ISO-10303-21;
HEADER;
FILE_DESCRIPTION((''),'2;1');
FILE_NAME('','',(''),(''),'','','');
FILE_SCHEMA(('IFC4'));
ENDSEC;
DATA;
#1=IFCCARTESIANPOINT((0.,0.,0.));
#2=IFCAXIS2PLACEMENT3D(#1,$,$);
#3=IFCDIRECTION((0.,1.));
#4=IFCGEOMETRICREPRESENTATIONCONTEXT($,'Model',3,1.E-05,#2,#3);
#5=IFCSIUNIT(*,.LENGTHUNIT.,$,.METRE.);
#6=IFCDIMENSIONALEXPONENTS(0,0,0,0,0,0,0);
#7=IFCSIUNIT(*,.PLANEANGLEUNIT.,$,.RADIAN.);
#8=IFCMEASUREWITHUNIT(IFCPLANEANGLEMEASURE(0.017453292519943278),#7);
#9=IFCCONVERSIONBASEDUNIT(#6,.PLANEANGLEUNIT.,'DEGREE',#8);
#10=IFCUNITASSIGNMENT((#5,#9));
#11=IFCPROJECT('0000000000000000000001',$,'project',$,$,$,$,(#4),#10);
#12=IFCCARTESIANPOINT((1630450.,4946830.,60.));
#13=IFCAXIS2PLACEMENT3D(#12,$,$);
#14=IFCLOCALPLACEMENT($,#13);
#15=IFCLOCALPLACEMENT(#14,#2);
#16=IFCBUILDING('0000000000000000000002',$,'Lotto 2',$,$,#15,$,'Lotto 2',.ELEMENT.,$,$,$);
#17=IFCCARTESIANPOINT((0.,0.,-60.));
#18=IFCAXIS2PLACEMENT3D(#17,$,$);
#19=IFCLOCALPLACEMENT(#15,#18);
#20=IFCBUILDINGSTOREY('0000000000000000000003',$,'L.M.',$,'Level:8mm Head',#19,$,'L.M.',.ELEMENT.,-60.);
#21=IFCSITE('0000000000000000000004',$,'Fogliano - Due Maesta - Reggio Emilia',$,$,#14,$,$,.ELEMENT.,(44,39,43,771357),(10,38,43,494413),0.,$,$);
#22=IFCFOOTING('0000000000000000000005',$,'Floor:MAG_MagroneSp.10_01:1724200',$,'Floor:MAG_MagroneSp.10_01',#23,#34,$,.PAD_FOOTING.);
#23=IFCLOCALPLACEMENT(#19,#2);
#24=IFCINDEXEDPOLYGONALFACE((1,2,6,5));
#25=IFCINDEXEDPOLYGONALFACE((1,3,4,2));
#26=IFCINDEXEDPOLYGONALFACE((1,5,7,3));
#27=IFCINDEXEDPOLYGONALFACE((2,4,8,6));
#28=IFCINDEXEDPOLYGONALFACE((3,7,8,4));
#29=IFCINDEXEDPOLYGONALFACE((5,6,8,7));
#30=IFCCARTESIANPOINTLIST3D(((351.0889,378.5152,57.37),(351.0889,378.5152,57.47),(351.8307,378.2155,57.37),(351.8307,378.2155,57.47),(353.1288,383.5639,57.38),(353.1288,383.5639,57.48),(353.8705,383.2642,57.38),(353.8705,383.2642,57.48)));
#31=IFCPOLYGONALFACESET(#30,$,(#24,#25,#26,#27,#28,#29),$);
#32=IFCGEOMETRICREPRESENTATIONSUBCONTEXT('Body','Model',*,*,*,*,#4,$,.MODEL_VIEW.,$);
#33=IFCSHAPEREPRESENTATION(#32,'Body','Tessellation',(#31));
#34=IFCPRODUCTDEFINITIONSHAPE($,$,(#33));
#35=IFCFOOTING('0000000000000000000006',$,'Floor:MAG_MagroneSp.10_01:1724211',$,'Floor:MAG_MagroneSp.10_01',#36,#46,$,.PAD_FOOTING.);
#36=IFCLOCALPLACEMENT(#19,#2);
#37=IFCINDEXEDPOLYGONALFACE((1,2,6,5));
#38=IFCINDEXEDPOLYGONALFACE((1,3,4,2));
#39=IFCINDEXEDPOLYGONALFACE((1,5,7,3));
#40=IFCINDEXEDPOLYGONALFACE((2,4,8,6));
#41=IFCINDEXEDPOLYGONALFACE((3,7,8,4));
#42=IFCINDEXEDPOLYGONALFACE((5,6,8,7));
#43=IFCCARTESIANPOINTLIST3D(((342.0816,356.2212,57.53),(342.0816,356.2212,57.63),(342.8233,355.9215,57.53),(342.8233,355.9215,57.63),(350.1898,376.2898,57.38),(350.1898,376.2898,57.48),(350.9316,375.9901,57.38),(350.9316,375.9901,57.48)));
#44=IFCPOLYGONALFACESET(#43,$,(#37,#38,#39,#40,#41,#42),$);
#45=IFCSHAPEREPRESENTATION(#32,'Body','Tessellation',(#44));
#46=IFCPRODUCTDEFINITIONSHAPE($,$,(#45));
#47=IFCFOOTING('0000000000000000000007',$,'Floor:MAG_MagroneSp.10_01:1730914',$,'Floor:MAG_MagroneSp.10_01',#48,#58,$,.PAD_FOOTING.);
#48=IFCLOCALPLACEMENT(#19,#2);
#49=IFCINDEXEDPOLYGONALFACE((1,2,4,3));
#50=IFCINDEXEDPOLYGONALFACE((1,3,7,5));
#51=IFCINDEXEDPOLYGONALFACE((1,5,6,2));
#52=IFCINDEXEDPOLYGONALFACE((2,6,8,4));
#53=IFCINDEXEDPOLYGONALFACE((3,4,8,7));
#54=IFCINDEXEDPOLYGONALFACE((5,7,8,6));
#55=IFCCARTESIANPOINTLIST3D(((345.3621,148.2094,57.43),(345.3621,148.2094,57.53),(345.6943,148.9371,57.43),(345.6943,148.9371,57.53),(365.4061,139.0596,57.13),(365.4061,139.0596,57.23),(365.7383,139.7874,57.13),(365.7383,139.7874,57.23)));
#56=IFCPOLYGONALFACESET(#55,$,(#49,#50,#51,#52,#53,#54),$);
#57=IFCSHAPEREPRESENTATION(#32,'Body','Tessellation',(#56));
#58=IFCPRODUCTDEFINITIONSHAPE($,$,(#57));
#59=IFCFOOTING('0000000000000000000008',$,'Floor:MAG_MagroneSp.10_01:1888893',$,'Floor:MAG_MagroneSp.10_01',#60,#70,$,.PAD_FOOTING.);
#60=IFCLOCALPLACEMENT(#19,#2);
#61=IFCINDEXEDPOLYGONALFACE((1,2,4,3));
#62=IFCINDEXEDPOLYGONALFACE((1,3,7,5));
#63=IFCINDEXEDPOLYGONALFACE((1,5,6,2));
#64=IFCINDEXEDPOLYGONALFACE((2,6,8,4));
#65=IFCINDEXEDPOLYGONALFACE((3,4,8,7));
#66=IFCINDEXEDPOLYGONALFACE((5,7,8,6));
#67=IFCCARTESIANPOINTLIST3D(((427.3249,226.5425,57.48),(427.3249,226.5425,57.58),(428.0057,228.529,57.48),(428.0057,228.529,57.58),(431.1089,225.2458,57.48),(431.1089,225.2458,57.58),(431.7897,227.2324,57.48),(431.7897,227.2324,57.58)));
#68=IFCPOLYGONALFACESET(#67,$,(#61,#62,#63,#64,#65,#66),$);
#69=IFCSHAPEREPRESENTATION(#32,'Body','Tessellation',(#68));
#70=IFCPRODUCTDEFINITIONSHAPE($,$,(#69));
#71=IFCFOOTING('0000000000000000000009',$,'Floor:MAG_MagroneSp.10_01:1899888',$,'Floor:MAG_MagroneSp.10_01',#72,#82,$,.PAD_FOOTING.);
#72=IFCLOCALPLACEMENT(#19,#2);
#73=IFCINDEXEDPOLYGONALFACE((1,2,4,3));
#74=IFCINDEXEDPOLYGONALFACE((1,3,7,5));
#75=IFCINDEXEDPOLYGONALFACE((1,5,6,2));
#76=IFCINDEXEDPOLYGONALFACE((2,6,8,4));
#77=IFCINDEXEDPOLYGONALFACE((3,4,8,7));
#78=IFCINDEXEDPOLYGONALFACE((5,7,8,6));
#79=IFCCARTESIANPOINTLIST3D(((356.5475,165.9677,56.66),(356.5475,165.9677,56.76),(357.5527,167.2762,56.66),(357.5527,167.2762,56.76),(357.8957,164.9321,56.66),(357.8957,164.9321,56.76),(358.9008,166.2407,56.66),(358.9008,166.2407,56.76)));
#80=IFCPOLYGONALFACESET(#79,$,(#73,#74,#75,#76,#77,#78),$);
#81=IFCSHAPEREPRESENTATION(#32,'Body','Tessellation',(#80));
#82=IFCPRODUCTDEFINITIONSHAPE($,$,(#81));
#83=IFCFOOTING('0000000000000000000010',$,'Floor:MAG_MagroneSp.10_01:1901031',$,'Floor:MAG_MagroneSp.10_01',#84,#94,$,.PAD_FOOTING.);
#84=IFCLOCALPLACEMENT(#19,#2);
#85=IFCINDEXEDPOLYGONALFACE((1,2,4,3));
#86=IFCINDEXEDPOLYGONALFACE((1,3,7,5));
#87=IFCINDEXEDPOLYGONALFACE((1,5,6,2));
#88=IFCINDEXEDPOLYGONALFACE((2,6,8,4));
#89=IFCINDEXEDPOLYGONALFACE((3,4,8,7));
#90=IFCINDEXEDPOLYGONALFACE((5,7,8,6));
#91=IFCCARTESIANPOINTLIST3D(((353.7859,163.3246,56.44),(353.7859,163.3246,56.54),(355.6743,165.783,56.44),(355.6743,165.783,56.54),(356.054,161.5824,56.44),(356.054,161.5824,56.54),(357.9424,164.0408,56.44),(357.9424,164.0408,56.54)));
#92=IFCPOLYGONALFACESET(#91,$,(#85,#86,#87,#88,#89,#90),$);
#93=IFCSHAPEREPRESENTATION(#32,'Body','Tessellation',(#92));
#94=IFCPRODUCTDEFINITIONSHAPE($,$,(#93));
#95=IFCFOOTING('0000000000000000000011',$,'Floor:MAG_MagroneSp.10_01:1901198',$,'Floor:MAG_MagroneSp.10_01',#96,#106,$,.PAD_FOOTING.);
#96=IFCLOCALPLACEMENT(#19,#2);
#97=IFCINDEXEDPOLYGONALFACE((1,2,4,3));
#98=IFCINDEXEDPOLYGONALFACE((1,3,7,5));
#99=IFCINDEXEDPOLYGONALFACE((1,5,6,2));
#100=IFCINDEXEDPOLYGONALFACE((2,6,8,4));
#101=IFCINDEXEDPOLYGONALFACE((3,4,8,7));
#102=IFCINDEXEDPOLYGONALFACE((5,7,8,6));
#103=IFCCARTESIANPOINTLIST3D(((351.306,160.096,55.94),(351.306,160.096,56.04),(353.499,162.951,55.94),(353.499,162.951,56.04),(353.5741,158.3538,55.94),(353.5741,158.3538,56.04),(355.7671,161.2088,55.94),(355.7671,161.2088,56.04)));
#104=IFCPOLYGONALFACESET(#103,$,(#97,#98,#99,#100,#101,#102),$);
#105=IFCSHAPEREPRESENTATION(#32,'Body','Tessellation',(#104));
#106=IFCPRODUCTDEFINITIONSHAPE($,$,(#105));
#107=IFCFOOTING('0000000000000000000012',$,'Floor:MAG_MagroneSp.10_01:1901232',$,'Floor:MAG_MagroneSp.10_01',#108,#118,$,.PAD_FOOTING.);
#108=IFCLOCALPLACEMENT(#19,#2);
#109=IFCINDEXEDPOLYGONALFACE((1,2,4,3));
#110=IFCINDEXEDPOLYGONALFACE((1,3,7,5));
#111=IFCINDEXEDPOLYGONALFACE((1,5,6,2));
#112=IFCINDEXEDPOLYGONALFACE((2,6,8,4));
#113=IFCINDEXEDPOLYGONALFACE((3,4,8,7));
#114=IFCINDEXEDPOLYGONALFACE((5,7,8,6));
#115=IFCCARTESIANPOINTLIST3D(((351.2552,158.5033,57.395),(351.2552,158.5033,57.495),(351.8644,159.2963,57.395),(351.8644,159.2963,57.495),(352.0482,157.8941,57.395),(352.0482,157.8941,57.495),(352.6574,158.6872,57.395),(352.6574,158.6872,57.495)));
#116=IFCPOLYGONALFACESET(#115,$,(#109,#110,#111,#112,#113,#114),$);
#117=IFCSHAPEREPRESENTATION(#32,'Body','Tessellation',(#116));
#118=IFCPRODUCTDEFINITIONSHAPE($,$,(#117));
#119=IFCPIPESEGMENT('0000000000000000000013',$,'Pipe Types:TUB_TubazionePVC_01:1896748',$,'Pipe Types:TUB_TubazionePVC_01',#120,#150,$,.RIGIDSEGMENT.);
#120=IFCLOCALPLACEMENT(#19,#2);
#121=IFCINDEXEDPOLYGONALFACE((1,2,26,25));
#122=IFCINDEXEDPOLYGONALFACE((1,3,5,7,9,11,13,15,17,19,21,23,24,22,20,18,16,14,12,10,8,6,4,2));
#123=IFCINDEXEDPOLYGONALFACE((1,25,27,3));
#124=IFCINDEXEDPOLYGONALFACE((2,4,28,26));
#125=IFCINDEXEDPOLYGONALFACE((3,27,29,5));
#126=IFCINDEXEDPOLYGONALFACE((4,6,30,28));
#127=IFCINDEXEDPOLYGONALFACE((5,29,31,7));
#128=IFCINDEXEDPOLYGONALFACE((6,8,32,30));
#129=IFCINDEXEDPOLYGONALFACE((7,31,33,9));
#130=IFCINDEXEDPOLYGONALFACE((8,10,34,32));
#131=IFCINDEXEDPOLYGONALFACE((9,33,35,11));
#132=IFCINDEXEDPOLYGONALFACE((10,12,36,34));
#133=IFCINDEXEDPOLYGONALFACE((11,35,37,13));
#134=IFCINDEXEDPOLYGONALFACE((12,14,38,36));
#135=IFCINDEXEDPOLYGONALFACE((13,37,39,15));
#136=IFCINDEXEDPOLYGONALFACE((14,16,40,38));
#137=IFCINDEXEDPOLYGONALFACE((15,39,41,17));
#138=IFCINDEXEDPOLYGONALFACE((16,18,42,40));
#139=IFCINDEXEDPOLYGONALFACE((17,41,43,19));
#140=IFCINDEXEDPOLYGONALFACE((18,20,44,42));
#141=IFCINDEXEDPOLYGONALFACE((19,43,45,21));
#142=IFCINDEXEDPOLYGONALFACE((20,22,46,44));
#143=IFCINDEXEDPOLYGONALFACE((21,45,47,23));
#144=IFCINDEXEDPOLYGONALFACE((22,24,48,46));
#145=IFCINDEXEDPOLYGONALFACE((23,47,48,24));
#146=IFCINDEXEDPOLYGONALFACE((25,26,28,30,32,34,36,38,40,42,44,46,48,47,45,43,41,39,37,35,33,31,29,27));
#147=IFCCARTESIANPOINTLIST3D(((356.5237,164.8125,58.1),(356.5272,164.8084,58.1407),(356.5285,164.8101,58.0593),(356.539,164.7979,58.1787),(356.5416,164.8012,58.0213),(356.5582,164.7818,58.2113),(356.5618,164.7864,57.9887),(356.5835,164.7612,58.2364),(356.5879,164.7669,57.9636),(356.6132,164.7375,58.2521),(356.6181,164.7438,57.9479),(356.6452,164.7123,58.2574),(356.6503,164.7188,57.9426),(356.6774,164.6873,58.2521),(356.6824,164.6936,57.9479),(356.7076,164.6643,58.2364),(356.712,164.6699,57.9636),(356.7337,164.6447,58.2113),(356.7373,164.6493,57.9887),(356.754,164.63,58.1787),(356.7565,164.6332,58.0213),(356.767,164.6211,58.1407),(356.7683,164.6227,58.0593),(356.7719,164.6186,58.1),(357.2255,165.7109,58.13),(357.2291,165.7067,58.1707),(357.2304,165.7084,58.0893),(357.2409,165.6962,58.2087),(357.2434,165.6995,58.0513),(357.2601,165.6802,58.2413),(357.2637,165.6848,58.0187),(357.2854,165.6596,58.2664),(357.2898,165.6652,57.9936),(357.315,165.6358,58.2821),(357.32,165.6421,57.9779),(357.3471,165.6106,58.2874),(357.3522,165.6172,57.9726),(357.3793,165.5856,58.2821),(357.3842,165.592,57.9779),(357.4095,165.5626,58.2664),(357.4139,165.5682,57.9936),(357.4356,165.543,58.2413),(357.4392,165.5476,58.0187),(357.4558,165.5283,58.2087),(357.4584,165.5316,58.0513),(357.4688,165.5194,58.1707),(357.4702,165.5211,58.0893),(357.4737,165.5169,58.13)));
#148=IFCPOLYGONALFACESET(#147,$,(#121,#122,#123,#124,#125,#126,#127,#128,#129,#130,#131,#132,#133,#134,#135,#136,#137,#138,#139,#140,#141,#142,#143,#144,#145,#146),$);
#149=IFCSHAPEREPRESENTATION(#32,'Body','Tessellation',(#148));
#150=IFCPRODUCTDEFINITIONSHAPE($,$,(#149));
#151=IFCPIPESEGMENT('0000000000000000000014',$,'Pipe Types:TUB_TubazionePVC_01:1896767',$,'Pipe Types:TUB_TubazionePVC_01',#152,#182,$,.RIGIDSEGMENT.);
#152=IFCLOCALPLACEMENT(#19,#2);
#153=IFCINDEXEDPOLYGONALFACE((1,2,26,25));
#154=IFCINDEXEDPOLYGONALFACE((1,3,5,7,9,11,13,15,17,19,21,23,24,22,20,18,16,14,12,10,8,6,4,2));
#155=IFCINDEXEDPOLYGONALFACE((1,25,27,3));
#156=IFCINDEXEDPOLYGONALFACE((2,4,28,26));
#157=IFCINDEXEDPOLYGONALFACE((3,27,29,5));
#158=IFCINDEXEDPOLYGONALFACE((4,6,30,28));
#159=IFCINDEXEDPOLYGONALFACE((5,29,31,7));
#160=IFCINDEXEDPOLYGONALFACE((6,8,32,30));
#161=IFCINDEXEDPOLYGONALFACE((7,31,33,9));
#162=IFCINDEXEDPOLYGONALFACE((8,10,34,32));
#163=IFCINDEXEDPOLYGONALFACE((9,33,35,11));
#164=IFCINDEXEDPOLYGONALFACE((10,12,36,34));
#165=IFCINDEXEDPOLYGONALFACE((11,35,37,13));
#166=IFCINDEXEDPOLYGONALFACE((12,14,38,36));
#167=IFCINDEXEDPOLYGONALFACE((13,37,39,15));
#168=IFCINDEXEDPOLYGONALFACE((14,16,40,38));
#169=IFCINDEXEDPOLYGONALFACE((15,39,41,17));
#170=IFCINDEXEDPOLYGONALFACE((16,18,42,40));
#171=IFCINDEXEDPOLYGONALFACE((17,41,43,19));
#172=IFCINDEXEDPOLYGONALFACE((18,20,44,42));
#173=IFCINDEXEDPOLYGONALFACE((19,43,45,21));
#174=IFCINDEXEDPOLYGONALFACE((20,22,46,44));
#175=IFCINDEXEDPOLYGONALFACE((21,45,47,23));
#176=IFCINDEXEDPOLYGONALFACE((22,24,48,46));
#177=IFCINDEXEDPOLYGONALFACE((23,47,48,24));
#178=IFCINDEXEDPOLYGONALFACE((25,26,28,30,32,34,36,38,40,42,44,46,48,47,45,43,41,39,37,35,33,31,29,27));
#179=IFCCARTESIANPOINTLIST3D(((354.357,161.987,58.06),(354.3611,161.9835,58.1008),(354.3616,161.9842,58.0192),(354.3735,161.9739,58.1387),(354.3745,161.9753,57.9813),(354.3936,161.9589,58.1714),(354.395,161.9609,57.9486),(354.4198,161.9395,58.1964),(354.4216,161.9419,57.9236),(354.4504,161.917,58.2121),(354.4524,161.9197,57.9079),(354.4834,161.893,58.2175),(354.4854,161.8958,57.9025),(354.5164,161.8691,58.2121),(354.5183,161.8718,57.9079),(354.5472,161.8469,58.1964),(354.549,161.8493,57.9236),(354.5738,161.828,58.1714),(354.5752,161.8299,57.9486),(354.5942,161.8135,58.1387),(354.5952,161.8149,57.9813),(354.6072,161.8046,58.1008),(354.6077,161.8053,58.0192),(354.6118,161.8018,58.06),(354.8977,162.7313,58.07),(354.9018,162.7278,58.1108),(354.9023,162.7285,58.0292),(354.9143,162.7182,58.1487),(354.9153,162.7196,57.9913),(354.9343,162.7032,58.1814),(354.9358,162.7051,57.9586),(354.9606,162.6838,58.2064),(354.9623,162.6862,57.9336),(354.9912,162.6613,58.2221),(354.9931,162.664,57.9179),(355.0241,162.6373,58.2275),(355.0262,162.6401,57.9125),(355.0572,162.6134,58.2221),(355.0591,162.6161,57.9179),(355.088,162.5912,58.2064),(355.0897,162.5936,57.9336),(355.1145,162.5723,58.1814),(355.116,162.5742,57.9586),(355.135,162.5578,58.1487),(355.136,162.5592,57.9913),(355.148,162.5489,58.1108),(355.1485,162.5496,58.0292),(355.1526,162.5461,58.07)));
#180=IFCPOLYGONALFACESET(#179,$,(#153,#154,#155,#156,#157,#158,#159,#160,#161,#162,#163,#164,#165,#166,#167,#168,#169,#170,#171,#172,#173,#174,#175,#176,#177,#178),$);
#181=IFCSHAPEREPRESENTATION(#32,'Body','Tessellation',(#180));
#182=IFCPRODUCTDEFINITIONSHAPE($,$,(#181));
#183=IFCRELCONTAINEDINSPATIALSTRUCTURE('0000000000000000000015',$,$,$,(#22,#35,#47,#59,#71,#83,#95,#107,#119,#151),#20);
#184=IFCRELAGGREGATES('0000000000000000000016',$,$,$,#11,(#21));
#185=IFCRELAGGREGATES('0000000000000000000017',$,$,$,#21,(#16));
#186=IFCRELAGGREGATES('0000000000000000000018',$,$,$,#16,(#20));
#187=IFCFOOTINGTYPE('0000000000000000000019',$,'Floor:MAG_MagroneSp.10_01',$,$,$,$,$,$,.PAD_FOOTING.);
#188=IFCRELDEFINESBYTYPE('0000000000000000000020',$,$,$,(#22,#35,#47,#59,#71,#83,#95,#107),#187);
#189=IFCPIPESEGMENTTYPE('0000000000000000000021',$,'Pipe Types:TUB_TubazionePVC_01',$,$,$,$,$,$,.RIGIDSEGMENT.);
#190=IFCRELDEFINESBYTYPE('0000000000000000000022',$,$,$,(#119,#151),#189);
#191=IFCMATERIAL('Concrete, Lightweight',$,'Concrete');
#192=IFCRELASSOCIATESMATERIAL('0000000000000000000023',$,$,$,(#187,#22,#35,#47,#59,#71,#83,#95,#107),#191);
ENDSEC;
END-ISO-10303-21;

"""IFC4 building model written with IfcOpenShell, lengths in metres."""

from ifc_helpers import new_model, entity, si_unit, converted_unit, direction, frame, frame_2d, origin, place, context, subcontext, project, spatial, arc, indexed_curve, rectangle, outline, extrude, material, type_object, element, save


model = new_model("IFC4")

# Units and contexts
model_context = context("Model", 3, precision=1e-05, world=origin(), true_north=direction((0.0, 1.0)))
body_context = subcontext(model_context, "Body", "Model", "MODEL_VIEW")
ifc_project = project(units=[si_unit("LENGTHUNIT", "METRE"), converted_unit("PLANEANGLEUNIT", "DEGREE", entity("IfcPlaneAngleMeasure", 0.017453292519943278), si_unit("PLANEANGLEUNIT", "RADIAN"), dimensions=[0, 0, 0, 0, 0, 0, 0])], contexts=[model_context])

# Site, building, storey
site_placement = place(None, frame((1630450.0, 4946830.0, 60.0)))
site = spatial("IfcSite", under=ifc_project, at=site_placement, Name="Fogliano - Due Maesta - Reggio Emilia", CompositionType="ELEMENT", RefLatitude=(44, 39, 43, 771357), RefLongitude=(10, 38, 43, 494413), RefElevation=0.0)
building_placement = place(site_placement, origin())
building = spatial("IfcBuilding", under=site, at=building_placement, Name="Lotto 2", LongName="Lotto 2", CompositionType="ELEMENT")
storey_placement = place(building_placement, frame((0.0, 0.0, -60.0)))
storey = spatial("IfcBuildingStorey", under=building, at=storey_placement, Name="L.M.", ObjectType="Level:8mm Head", LongName="L.M.", CompositionType="ELEMENT", Elevation=-60.0)

# Footings
ifc_material_1 = material(Name="Concrete, Lightweight", Category="Concrete")
footing_type = type_object("IfcFootingType", Name="Floor:MAG_MagroneSp.10_01", PredefinedType="PAD_FOOTING", material=ifc_material_1)
footing_1_placement = place(storey_placement, frame((351.0889, 378.2155, 57.37)))
element("IfcFooting", 1, at=footing_1_placement, inside=storey, type_object=footing_type, material=ifc_material_1, Name="Floor:MAG_MagroneSp.10_01:1724200", ObjectType="Floor:MAG_MagroneSp.10_01", PredefinedType="PAD_FOOTING", context=body_context, shape_type="SweptSolid", body=[
    extrude(rectangle(XDim=0.8, YDim=5.4452, at=frame_2d((0.0, 0.0), x_axis=(0.927184, -0.374606))), frame((1.3908, 2.6742, 0.105), z_axis=(-0.000688, -0.001703, 0.999998), x_axis=(1.0, -0.000001, 0.000688)), (-0.000688, -0.001703, -0.999998), 0.1),
])
footing_2_placement = place(storey_placement, frame((342.0816, 355.9215, 57.38)))
element("IfcFooting", 2, at=footing_2_placement, inside=storey, type_object=footing_type, material=ifc_material_1, Name="Floor:MAG_MagroneSp.10_01:1724211", ObjectType="Floor:MAG_MagroneSp.10_01", PredefinedType="PAD_FOOTING", context=body_context, shape_type="SweptSolid", body=[
    extrude(rectangle(XDim=0.8, YDim=21.6452, at=frame_2d((0.0, 0.0), x_axis=(0.927187, -0.374599))), frame((4.425, 10.1841, 0.175), z_axis=(0.002596, 0.006425, 0.999976), x_axis=(0.999997, -0.000017, -0.002596)), (0.002596, 0.006425, -0.999976), 0.1),
])
footing_3_placement = place(storey_placement, frame((345.3621, 139.0596, 57.13)))
element("IfcFooting", 3, at=footing_3_placement, inside=storey, type_object=footing_type, material=ifc_material_1, Name="Floor:MAG_MagroneSp.10_01:1730914", ObjectType="Floor:MAG_MagroneSp.10_01", PredefinedType="PAD_FOOTING", context=body_context, shape_type="SweptSolid", body=[
    extrude(rectangle(XDim=0.8, YDim=22.0356, at=frame_2d((0.0, 0.0), x_axis=(0.415297, 0.909686))), frame((10.1881, 4.9388, 0.25), z_axis=(0.012386, -0.005654, 0.999907), x_axis=(0.999923, 0.00007, -0.012386)), (0.012386, -0.005654, -0.999907), 0.1),
])
footing_4_placement = place(storey_placement, origin())
element("IfcFooting", 4, at=footing_4_placement, inside=storey, type_object=footing_type, material=ifc_material_1, Name="Floor:MAG_MagroneSp.10_01:1888893", ObjectType="Floor:MAG_MagroneSp.10_01", PredefinedType="PAD_FOOTING", context=body_context, shape_type="SweptSolid", body=[
    extrude(outline(indexed_curve([(-2.0, -1.05), (2.0, -1.05), (2.0, 1.05), (-2.0, 1.05), (-2.0, -1.05)], self_intersect=False)), frame((429.5573, 226.8874, 57.58), z_axis=(0.0, 0.0, -1.0), x_axis=(0.945998, -0.324172, 0.0)), (0.0, 0.0, 1.0), 0.1),
])
footing_5_placement = place(storey_placement, origin())
element("IfcFooting", 5, at=footing_5_placement, inside=storey, type_object=footing_type, material=ifc_material_1, Name="Floor:MAG_MagroneSp.10_01:1899888", ObjectType="Floor:MAG_MagroneSp.10_01", PredefinedType="PAD_FOOTING", context=body_context, shape_type="SweptSolid", body=[
    extrude(outline(indexed_curve([(-0.85, -0.825), (0.85, -0.825), (0.85, 0.825), (-0.85, 0.825), (-0.85, -0.825)], self_intersect=False)), frame((357.7242, 166.1042, 56.76), z_axis=(0.0, 0.0, -1.0), x_axis=(0.793045, -0.609163, 0.0)), (0.0, 0.0, 1.0), 0.1),
])
footing_6_placement = place(storey_placement, origin())
element("IfcFooting", 6, at=footing_6_placement, inside=storey, type_object=footing_type, material=ifc_material_1, Name="Floor:MAG_MagroneSp.10_01:1901031", ObjectType="Floor:MAG_MagroneSp.10_01", PredefinedType="PAD_FOOTING", context=body_context, shape_type="SweptSolid", body=[
    extrude(outline(indexed_curve([(-1.43, -1.55), (1.43, -1.55), (1.43, 1.55), (-1.43, 1.55), (-1.43, -1.55)], self_intersect=False)), frame((355.8642, 163.6827, 56.54), z_axis=(0.0, 0.0, -1.0), x_axis=(0.793045, -0.609163, 0.0)), (0.0, 0.0, 1.0), 0.1),
])
footing_7_placement = place(storey_placement, origin())
element("IfcFooting", 7, at=footing_7_placement, inside=storey, type_object=footing_type, material=ifc_material_1, Name="Floor:MAG_MagroneSp.10_01:1901198", ObjectType="Floor:MAG_MagroneSp.10_01", PredefinedType="PAD_FOOTING", context=body_context, shape_type="SweptSolid", body=[
    extrude(outline(indexed_curve([(-1.43, -1.8), (1.43, -1.8), (1.43, 1.8), (-1.43, 1.8), (-1.43, -1.8)], self_intersect=False)), frame((353.5365, 160.6524, 56.04), z_axis=(0.0, 0.0, -1.0), x_axis=(0.793045, -0.609163, 0.0)), (0.0, 0.0, 1.0), 0.1),
])
footing_8_placement = place(storey_placement, origin())
element("IfcFooting", 8, at=footing_8_placement, inside=storey, type_object=footing_type, material=ifc_material_1, Name="Floor:MAG_MagroneSp.10_01:1901232", ObjectType="Floor:MAG_MagroneSp.10_01", PredefinedType="PAD_FOOTING", context=body_context, shape_type="SweptSolid", body=[
    extrude(outline(indexed_curve([(-0.5, -0.5), (0.5, -0.5), (0.5, 0.5), (-0.5, 0.5), (-0.5, -0.5)], self_intersect=False)), frame((351.9563, 158.5952, 57.495), z_axis=(0.0, 0.0, -1.0), x_axis=(0.793045, -0.609163, 0.0)), (0.0, 0.0, 1.0), 0.1),
])

# Pipe segments
pipe_segment_type_1 = type_object("IfcPipeSegmentType", Name="Pipe Types:TUB_TubazionePVC_01", PredefinedType="RIGIDSEGMENT")
pipe_segment_1_placement = place(storey_placement, origin())
element("IfcPipeSegment", 9, at=pipe_segment_1_placement, inside=storey, type_object=pipe_segment_type_1, Name="Pipe Types:TUB_TubazionePVC_01:1896748", ObjectType="Pipe Types:TUB_TubazionePVC_01", PredefinedType="RIGIDSEGMENT", context=body_context, shape_type="SweptSolid", body=[
    extrude(outline(indexed_curve([(0.1575, 0.0), (0.1114, 0.1114), (0.0, 0.1575), (-0.1114, 0.1114), (-0.1575, 0.0), (-0.1114, -0.1114), (0.0, -0.1575), (0.1114, -0.1114)], segments=[arc(1, 2, 3), arc(3, 4, 5), arc(5, 6, 7), arc(7, 8, 1)], self_intersect=False)), frame((356.6478, 164.7156, 58.1), z_axis=(0.615448, 0.787738, 0.026307), x_axis=(-0.788011, 0.615661, 0.0)), (0.0, 0.0, 1.0), 1.1404),
])
pipe_segment_2_placement = place(storey_placement, origin())
element("IfcPipeSegment", 10, at=pipe_segment_2_placement, inside=storey, type_object=pipe_segment_type_1, Name="Pipe Types:TUB_TubazionePVC_01:1896767", ObjectType="Pipe Types:TUB_TubazionePVC_01", PredefinedType="RIGIDSEGMENT", context=body_context, shape_type="SweptSolid", body=[
    extrude(outline(indexed_curve([(0.1575, 0.0), (0.1114, 0.1114), (0.0, 0.1575), (-0.1114, 0.1114), (-0.1575, 0.0), (-0.1114, -0.1114), (0.0, -0.1575), (0.1114, -0.1114)], segments=[arc(1, 2, 3), arc(3, 4, 5), arc(5, 6, 7), arc(7, 8, 1)], self_intersect=False)), frame((354.4844, 161.8944, 58.06), z_axis=(0.587751, 0.808969, 0.010869), x_axis=(-0.809017, 0.587785, 0.0)), (0.0, 0.0, 1.0), 0.9201),
])

save(model, "model.ifc")
